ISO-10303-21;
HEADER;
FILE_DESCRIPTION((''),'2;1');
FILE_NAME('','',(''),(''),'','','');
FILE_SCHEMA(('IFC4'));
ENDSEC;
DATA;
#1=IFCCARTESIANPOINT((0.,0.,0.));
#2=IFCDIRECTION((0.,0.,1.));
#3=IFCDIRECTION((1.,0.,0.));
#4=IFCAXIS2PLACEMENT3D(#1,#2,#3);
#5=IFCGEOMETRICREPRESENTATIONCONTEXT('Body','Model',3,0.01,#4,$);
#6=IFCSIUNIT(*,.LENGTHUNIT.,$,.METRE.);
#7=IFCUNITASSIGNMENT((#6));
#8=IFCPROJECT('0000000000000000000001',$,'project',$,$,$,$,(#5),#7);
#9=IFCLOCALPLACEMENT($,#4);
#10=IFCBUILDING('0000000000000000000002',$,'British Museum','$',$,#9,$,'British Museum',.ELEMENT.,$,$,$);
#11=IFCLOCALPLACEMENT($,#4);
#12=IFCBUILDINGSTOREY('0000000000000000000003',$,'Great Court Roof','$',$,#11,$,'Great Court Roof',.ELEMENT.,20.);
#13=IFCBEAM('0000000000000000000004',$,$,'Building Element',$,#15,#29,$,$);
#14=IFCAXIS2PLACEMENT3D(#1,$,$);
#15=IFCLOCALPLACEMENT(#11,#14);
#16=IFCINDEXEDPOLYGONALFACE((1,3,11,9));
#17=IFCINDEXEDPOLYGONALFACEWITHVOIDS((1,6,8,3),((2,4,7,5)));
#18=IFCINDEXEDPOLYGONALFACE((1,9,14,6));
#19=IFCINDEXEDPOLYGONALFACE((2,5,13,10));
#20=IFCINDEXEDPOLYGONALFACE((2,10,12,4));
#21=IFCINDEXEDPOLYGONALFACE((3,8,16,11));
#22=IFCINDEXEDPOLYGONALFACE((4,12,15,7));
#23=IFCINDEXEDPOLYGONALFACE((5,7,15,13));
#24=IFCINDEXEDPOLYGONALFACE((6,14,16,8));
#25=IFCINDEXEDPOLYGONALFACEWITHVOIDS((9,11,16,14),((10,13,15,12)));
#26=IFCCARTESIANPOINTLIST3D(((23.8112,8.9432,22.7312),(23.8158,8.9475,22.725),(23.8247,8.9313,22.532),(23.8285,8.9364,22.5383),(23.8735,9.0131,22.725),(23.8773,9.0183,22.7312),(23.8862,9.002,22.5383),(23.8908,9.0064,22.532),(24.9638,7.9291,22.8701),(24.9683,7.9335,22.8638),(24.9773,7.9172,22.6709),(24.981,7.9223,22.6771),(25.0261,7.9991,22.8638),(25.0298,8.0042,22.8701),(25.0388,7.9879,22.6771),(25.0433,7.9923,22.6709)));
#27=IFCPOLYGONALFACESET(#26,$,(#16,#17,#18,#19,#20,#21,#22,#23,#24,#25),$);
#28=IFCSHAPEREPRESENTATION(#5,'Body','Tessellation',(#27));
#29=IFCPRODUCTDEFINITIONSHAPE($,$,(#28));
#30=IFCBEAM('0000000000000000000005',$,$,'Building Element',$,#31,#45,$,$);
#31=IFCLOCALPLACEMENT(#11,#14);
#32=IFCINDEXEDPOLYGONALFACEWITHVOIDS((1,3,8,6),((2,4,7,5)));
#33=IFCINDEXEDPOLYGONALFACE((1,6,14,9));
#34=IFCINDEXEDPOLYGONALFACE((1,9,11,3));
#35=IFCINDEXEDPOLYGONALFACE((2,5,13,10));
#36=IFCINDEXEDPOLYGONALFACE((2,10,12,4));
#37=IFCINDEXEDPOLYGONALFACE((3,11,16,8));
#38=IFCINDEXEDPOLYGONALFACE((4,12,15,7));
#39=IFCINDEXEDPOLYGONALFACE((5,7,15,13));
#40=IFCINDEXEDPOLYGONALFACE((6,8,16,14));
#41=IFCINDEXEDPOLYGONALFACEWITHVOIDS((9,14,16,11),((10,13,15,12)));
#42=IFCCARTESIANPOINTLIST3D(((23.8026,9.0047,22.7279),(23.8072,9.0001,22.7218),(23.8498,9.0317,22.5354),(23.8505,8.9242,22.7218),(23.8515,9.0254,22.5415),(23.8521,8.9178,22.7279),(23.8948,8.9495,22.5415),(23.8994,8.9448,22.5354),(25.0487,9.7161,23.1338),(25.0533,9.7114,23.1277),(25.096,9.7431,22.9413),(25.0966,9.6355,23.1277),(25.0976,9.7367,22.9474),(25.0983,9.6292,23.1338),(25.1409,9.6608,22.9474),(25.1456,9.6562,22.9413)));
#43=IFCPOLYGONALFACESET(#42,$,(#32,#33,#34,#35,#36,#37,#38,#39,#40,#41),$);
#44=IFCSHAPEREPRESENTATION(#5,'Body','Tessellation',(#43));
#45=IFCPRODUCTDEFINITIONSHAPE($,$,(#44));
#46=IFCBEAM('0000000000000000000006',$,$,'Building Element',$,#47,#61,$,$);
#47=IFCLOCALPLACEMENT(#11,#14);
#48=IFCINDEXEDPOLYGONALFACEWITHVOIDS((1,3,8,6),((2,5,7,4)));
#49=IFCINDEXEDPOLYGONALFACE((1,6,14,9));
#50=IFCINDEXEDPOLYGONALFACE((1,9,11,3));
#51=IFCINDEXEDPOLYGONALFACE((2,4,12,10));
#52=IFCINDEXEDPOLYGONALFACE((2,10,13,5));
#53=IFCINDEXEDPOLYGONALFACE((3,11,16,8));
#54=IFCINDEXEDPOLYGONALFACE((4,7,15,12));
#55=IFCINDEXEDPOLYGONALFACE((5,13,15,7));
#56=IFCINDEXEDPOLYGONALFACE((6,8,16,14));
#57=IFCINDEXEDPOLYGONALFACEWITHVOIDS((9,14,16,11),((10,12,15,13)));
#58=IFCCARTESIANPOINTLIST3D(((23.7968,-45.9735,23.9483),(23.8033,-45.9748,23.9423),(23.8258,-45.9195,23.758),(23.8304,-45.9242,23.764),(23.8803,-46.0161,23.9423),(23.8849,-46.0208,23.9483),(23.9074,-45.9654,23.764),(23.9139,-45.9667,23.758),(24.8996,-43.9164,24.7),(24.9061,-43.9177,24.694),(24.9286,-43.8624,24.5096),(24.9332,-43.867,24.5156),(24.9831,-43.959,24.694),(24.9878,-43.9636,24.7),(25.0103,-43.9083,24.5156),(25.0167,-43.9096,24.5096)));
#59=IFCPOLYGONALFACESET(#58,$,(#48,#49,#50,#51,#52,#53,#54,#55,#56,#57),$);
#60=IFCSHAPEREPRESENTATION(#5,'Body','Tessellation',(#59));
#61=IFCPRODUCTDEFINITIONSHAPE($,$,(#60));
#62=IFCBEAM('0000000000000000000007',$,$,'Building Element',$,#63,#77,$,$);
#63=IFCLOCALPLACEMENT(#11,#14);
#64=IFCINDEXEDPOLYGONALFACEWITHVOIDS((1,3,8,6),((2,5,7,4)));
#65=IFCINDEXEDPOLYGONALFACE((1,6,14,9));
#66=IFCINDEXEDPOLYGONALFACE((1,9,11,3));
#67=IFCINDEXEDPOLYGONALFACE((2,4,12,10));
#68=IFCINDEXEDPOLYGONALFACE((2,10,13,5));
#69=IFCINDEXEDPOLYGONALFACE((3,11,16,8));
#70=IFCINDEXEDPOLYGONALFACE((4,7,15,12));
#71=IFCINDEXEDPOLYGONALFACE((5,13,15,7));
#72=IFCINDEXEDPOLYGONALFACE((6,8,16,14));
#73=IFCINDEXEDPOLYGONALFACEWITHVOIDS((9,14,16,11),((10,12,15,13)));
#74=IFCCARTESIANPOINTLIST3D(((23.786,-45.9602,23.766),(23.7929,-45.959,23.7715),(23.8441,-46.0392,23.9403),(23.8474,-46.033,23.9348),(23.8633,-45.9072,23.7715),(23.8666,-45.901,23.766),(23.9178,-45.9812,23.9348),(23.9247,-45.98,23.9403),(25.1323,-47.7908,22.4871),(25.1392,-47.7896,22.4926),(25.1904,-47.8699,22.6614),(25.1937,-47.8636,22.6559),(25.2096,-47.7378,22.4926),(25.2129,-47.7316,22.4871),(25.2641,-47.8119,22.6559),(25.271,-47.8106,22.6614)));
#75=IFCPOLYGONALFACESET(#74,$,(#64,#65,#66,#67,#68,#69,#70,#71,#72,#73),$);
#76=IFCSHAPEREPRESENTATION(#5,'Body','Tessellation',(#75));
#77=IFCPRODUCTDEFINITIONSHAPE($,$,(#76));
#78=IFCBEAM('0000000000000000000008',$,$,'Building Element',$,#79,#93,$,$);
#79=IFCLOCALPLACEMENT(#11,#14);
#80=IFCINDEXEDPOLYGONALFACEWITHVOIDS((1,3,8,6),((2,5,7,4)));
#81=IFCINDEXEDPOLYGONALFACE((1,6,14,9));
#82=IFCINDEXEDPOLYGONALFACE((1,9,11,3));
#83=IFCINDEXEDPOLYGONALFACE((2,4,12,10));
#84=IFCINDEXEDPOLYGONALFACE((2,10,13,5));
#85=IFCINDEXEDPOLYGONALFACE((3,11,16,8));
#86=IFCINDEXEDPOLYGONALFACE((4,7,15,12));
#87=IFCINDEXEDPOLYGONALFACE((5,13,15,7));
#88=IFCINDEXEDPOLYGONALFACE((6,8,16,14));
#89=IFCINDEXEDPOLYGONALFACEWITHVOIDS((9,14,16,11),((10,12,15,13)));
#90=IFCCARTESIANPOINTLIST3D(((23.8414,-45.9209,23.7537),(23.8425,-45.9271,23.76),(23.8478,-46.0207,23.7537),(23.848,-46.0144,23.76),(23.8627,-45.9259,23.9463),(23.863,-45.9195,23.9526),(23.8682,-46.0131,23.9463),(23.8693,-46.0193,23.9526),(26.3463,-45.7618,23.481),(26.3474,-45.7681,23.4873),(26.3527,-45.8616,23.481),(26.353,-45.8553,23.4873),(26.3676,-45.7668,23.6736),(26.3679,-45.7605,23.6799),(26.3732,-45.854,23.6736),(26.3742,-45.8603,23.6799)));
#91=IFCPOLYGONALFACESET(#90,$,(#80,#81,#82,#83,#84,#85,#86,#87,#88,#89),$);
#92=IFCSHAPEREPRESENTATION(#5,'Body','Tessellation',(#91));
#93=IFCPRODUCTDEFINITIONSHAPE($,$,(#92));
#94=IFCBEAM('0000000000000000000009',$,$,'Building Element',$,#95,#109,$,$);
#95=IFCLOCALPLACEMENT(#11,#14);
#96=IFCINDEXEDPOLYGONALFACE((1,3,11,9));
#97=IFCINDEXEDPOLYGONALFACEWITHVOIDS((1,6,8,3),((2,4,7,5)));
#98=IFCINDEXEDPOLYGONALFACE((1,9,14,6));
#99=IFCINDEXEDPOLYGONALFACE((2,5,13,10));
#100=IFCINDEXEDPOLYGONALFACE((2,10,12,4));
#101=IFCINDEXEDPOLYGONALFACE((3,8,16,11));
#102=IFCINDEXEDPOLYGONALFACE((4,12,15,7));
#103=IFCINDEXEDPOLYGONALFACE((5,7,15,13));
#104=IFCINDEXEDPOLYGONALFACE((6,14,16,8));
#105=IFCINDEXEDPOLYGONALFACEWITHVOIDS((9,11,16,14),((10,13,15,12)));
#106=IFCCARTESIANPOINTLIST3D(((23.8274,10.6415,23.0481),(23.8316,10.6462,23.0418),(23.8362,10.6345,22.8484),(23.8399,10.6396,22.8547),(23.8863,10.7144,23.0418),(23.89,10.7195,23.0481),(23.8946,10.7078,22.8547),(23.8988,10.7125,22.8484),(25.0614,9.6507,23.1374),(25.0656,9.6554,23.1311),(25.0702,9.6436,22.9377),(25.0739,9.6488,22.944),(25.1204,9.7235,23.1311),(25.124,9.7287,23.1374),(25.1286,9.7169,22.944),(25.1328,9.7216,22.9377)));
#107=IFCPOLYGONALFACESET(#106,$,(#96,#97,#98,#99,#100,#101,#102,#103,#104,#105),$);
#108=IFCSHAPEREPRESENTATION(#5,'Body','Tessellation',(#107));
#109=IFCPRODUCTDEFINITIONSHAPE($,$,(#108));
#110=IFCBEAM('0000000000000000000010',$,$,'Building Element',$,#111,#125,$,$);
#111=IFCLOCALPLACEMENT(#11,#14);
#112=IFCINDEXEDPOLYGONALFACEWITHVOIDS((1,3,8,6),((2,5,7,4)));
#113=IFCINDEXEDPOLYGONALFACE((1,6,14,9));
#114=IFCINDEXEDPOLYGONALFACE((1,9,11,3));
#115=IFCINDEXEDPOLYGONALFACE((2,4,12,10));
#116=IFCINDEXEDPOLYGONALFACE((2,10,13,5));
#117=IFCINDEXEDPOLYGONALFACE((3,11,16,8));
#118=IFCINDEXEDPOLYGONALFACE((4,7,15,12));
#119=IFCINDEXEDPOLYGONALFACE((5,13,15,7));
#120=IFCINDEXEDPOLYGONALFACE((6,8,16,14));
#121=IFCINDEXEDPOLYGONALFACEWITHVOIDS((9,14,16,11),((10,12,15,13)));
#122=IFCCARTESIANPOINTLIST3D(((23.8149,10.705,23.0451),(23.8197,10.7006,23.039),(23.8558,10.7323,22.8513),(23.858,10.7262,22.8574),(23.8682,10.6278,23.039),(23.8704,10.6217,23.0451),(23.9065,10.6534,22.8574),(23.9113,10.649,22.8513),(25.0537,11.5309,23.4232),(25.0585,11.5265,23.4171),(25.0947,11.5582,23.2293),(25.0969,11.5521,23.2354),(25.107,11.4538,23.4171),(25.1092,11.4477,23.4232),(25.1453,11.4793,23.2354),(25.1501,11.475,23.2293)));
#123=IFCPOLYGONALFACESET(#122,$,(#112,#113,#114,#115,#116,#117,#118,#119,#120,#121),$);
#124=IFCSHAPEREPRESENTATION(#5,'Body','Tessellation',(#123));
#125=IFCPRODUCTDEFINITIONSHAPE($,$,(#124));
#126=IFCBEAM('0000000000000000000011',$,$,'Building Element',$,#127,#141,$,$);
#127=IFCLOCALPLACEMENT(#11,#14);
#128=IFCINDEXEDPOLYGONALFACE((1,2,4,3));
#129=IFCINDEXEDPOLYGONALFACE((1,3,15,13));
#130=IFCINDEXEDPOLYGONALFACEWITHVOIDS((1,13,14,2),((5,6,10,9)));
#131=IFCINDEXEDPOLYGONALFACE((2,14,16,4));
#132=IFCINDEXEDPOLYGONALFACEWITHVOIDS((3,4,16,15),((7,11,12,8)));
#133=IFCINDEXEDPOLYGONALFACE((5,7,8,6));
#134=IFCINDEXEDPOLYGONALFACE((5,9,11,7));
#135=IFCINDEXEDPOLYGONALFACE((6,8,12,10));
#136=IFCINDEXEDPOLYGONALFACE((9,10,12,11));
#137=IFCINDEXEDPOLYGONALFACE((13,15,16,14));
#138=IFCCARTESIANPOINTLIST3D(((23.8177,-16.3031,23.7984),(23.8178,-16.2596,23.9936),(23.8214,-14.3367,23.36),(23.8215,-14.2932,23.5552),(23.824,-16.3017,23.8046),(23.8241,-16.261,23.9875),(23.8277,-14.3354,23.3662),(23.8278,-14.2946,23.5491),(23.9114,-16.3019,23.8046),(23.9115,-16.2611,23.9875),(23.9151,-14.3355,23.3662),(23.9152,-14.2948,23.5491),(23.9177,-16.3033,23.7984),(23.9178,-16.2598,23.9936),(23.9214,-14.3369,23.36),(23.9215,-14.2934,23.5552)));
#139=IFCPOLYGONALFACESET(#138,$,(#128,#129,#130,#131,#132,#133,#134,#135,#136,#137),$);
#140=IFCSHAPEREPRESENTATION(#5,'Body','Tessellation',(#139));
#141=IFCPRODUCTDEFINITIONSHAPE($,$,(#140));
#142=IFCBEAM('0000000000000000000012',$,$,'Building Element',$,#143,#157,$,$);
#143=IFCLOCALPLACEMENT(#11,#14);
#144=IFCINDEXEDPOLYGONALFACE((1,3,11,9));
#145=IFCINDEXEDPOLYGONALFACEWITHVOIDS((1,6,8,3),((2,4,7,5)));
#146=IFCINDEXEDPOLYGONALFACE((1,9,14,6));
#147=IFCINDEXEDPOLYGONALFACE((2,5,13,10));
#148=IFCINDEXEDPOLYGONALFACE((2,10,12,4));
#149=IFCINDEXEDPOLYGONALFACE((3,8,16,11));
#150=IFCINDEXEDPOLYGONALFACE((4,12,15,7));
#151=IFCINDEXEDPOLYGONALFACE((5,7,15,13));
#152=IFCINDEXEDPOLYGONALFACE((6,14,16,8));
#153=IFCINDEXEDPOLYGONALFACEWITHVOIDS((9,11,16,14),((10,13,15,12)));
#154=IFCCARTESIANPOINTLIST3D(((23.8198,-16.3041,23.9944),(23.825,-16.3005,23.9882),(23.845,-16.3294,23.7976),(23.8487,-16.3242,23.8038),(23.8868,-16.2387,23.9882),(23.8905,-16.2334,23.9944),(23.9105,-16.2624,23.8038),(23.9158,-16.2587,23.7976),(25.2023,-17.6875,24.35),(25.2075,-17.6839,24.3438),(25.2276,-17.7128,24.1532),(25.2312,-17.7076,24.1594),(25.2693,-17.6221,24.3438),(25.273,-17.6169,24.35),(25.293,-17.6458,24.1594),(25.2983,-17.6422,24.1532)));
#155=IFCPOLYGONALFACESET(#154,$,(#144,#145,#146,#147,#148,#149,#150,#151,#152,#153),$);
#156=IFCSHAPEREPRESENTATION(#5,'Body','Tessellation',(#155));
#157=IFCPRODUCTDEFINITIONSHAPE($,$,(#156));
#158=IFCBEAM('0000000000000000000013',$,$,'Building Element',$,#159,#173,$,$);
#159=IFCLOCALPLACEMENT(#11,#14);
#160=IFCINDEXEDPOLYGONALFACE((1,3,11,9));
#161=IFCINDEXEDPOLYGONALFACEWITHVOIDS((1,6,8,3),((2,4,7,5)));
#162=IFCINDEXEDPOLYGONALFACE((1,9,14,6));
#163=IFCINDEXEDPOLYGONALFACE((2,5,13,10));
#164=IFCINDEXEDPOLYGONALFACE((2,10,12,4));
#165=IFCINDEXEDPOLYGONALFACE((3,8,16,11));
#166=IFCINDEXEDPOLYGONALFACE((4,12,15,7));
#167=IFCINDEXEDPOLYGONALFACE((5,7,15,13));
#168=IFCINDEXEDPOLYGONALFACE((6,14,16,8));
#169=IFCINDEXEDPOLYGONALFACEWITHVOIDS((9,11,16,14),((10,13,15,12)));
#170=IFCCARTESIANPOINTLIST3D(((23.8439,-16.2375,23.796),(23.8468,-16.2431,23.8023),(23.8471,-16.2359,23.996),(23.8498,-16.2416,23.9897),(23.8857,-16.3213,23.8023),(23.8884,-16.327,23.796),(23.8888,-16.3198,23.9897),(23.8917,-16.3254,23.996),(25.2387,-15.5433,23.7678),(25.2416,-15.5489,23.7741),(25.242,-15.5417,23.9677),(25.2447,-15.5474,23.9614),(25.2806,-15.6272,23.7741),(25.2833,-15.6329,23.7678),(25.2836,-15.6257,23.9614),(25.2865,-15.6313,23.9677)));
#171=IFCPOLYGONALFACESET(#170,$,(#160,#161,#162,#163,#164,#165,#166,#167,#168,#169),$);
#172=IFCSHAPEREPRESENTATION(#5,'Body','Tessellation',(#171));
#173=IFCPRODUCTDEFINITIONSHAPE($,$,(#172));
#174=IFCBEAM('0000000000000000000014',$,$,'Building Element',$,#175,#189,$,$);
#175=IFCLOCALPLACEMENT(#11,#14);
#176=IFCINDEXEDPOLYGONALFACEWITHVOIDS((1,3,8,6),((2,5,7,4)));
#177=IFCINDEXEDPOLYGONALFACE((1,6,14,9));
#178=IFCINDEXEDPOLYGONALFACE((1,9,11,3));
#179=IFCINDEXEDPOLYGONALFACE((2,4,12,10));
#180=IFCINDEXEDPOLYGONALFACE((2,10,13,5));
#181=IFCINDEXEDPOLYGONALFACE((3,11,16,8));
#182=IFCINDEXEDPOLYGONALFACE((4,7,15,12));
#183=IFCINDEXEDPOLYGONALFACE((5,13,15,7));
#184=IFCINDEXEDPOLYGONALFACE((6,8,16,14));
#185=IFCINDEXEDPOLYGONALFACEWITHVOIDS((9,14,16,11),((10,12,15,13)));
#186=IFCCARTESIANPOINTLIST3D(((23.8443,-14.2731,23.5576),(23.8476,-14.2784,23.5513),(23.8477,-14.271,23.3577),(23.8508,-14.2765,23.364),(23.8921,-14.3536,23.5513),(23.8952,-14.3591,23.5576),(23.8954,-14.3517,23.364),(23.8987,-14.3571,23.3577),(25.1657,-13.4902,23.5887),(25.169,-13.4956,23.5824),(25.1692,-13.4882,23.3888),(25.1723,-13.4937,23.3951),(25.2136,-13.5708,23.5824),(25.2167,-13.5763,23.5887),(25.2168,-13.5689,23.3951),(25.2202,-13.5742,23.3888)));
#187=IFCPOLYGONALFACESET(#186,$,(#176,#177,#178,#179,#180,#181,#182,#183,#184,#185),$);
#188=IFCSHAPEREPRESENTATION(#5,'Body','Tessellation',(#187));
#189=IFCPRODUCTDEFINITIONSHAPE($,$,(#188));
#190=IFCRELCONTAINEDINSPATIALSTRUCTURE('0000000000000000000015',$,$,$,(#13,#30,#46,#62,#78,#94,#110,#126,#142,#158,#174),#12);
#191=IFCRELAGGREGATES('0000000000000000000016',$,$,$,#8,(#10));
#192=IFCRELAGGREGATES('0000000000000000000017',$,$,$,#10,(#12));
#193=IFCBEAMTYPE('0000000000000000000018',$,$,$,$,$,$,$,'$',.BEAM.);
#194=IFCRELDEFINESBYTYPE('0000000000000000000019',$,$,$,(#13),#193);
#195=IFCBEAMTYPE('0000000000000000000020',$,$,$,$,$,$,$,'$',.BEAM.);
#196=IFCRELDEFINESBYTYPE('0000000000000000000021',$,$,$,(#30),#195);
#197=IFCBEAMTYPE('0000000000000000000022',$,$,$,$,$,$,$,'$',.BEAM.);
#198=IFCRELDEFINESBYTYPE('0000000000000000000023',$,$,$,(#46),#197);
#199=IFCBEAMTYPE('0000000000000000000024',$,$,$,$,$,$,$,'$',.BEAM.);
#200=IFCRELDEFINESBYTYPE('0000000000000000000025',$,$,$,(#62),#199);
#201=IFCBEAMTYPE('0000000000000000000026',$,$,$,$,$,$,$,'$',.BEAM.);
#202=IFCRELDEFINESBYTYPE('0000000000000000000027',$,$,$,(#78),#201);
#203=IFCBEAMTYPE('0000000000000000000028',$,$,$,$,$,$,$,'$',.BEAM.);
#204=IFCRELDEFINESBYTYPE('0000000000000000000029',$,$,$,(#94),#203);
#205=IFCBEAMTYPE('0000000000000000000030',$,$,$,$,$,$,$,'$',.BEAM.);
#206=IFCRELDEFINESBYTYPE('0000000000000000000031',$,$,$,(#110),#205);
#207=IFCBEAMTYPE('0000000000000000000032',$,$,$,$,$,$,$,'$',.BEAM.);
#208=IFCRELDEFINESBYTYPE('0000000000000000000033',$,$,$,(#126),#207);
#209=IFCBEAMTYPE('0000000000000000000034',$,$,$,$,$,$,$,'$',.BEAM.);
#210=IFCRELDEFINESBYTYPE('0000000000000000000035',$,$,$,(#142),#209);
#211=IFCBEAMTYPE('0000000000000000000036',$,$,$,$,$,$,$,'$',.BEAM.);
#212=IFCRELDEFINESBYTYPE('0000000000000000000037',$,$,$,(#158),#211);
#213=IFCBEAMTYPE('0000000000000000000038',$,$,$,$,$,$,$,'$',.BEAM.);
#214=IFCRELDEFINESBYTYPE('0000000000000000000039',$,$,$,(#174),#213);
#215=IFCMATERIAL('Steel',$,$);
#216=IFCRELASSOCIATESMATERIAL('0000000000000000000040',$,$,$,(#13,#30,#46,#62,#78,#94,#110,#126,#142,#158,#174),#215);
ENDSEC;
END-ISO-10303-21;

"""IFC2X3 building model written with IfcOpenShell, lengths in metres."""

from ifc_helpers import new_model, si_unit, frame, origin_with_axes, origin_2d, place, context, project, spatial, hollow_rectangle, extrude, material, type_object, element, save


model = new_model("IFC2X3")

# Units and contexts
model_context = context("Model", 3, precision=0.01, world=origin_with_axes(), identifier="Body")
ifc_project = project(units=[si_unit("LENGTHUNIT", "METRE")], contexts=[model_context])

# Building, storey
building_placement = place(None, origin_with_axes())
building = spatial("IfcBuilding", under=ifc_project, at=building_placement, Name="British Museum", Description="$", LongName="British Museum", CompositionType="ELEMENT")
storey_placement = place(None, origin_with_axes())
storey = spatial("IfcBuildingStorey", under=building, at=storey_placement, Name="Great Court Roof", Description="$", LongName="Great Court Roof", CompositionType="ELEMENT", Elevation=20.0)

# Beams
ifc_material = material(Name="Steel")
beam_type_1 = type_object("IfcBeamType", ElementType="$", PredefinedType="BEAM")
beam_1_placement = place(None, origin_with_axes())
element("IfcBeam", 1, at=beam_1_placement, inside=storey, type_object=beam_type_1, material=ifc_material, Description="Building Element", context=model_context, shape_type="SweptSolid", body=[
    extrude(hollow_rectangle(XDim=0.1, YDim=0.2, WallThickness=0.0063, InnerFilletRadius=-0.0063, OuterFilletRadius=0.0, at=origin_2d()), frame((23.851, 8.9748, 22.6316), z_axis=(0.747723, -0.657874, 0.090064), x_axis=(0.660558, 0.750775, 0.0)), (0.0, 0.0, 1.0), 1.5414),
])
beam_type_2 = type_object("IfcBeamType", ElementType="$", PredefinedType="BEAM")
beam_2_placement = place(None, origin_with_axes())
element("IfcBeam", 2, at=beam_2_placement, inside=storey, type_object=beam_type_2, material=ifc_material, Description="Building Element", context=model_context, shape_type="SweptSolid", body=[
    extrude(hollow_rectangle(XDim=0.1, YDim=0.2, WallThickness=0.0063, InnerFilletRadius=-0.0063, OuterFilletRadius=0.0, at=origin_2d()), frame((23.851, 8.9748, 22.6316), z_axis=(0.835664, 0.477052, 0.272189), x_axis=(-0.495771, 0.868453, 0.0)), (0.0, 0.0, 1.0), 1.4912),
])
beam_type_3 = type_object("IfcBeamType", ElementType="$", PredefinedType="BEAM")
beam_3_placement = place(None, origin_with_axes())
element("IfcBeam", 3, at=beam_3_placement, inside=storey, type_object=beam_type_3, material=ifc_material, Description="Building Element", context=model_context, shape_type="SweptSolid", body=[
    extrude(hollow_rectangle(XDim=0.1, YDim=0.2, WallThickness=0.0063, InnerFilletRadius=-0.0063, OuterFilletRadius=0.0, at=origin_2d()), frame((23.8554, -45.9701, 23.8531), z_axis=(0.44974, 0.838908, 0.30654), x_axis=(-0.881338, 0.472487, 0.0)), (0.0, 0.0, 1.0), 2.4521),
])
beam_type_4 = type_object("IfcBeamType", ElementType="$", PredefinedType="BEAM")
beam_4_placement = place(None, origin_with_axes())
element("IfcBeam", 4, at=beam_4_placement, inside=storey, type_object=beam_type_4, material=ifc_material, Description="Building Element", context=model_context, shape_type="SweptSolid", body=[
    extrude(hollow_rectangle(XDim=0.1, YDim=0.2, WallThickness=0.0063, InnerFilletRadius=-0.0063, OuterFilletRadius=0.0, at=origin_2d()), frame((23.8554, -45.9701, 23.8531), z_axis=(0.516315, -0.702051, -0.490451), x_axis=(0.805596, 0.592466, 0.0)), (0.0, 0.0, 1.0), 2.6075),
])
beam_type_5 = type_object("IfcBeamType", ElementType="$", PredefinedType="BEAM")
beam_5_placement = place(None, origin_with_axes())
element("IfcBeam", 5, at=beam_5_placement, inside=storey, type_object=beam_type_5, material=ifc_material, Description="Building Element", context=model_context, shape_type="SweptSolid", body=[
    extrude(hollow_rectangle(XDim=0.1, YDim=0.2, WallThickness=0.0063, InnerFilletRadius=-0.0063, OuterFilletRadius=0.0, at=origin_2d()), frame((23.8554, -45.9701, 23.8531), z_axis=(0.992152, 0.062998, -0.10801), x_axis=(-0.063369, 0.99799, 0.0)), (0.0, 0.0, 1.0), 2.5247),
])
beam_type_6 = type_object("IfcBeamType", ElementType="$", PredefinedType="BEAM")
beam_6_placement = place(None, origin_with_axes())
element("IfcBeam", 6, at=beam_6_placement, inside=storey, type_object=beam_type_6, material=ifc_material, Description="Building Element", context=model_context, shape_type="SweptSolid", body=[
    extrude(hollow_rectangle(XDim=0.1, YDim=0.2, WallThickness=0.0063, InnerFilletRadius=-0.0063, OuterFilletRadius=0.0, at=origin_2d()), frame((23.8631, 10.677, 22.9482), z_axis=(0.778509, -0.6251, 0.056344), x_axis=(0.626094, 0.779747, 0.0)), (0.0, 0.0, 1.0), 1.5851),
])
beam_type_7 = type_object("IfcBeamType", ElementType="$", PredefinedType="BEAM")
beam_7_placement = place(None, origin_with_axes())
element("IfcBeam", 7, at=beam_7_placement, inside=storey, type_object=beam_type_7, material=ifc_material, Description="Building Element", context=model_context, shape_type="SweptSolid", body=[
    extrude(hollow_rectangle(XDim=0.1, YDim=0.2, WallThickness=0.0063, InnerFilletRadius=-0.0063, OuterFilletRadius=0.0, at=origin_2d()), frame((23.8631, 10.677, 22.9482), z_axis=(0.806451, 0.537656, 0.246097), x_axis=(-0.554716, 0.83204, 0.0)), (0.0, 0.0, 1.0), 1.5361),
])
beam_type_8 = type_object("IfcBeamType", ElementType="$", PredefinedType="BEAM")
beam_8_placement = place(None, origin_with_axes())
element("IfcBeam", 8, at=beam_8_placement, inside=storey, type_object=beam_type_8, material=ifc_material, Description="Building Element", context=model_context, shape_type="SweptSolid", body=[
    extrude(hollow_rectangle(XDim=0.1, YDim=0.2, WallThickness=0.0063, InnerFilletRadius=-0.0063, OuterFilletRadius=0.0, at=origin_2d()), frame((23.8678, -16.2814, 23.896), z_axis=(0.001844, 0.976038, -0.217593), x_axis=(-0.999998, 0.001889, 0.0)), (0.0, 0.0, 1.0), 2.0146),
])
beam_type_9 = type_object("IfcBeamType", ElementType="$", PredefinedType="BEAM")
beam_9_placement = place(None, origin_with_axes())
element("IfcBeam", 9, at=beam_9_placement, inside=storey, type_object=beam_type_9, material=ifc_material, Description="Building Element", context=model_context, shape_type="SweptSolid", body=[
    extrude(hollow_rectangle(XDim=0.1, YDim=0.2, WallThickness=0.0063, InnerFilletRadius=-0.0063, OuterFilletRadius=0.0, at=origin_2d()), frame((23.8678, -16.2814, 23.896), z_axis=(0.695476, -0.695927, 0.178883), x_axis=(0.707336, 0.706877, 0.0)), (0.0, 0.0, 1.0), 1.9879),
])
beam_type_10 = type_object("IfcBeamType", ElementType="$", PredefinedType="BEAM")
beam_10_placement = place(None, origin_with_axes())
element("IfcBeam", 10, at=beam_10_placement, inside=storey, type_object=beam_type_10, material=ifc_material, Description="Building Element", context=model_context, shape_type="SweptSolid", body=[
    extrude(hollow_rectangle(XDim=0.1, YDim=0.2, WallThickness=0.0063, InnerFilletRadius=-0.0063, OuterFilletRadius=0.0, at=origin_2d()), frame((23.8678, -16.2814, 23.896), z_axis=(0.895124, 0.445447, -0.01814), x_axis=(-0.445521, 0.895272, 0.0)), (0.0, 0.0, 1.0), 1.5583),
])
beam_type_11 = type_object("IfcBeamType", ElementType="$", PredefinedType="BEAM")
beam_11_placement = place(None, origin_with_axes())
element("IfcBeam", 11, at=beam_11_placement, inside=storey, type_object=beam_type_11, material=ifc_material, Description="Building Element", context=model_context, shape_type="SweptSolid", body=[
    extrude(hollow_rectangle(XDim=0.1, YDim=0.2, WallThickness=0.0063, InnerFilletRadius=-0.0063, OuterFilletRadius=0.0, at=origin_2d()), frame((23.8715, -14.3151, 23.4576), z_axis=(0.860186, 0.509579, 0.02025), x_axis=(-0.509683, 0.860362, 0.0)), (0.0, 0.0, 1.0), 1.5363),
])

save(model, "model.ifc")
